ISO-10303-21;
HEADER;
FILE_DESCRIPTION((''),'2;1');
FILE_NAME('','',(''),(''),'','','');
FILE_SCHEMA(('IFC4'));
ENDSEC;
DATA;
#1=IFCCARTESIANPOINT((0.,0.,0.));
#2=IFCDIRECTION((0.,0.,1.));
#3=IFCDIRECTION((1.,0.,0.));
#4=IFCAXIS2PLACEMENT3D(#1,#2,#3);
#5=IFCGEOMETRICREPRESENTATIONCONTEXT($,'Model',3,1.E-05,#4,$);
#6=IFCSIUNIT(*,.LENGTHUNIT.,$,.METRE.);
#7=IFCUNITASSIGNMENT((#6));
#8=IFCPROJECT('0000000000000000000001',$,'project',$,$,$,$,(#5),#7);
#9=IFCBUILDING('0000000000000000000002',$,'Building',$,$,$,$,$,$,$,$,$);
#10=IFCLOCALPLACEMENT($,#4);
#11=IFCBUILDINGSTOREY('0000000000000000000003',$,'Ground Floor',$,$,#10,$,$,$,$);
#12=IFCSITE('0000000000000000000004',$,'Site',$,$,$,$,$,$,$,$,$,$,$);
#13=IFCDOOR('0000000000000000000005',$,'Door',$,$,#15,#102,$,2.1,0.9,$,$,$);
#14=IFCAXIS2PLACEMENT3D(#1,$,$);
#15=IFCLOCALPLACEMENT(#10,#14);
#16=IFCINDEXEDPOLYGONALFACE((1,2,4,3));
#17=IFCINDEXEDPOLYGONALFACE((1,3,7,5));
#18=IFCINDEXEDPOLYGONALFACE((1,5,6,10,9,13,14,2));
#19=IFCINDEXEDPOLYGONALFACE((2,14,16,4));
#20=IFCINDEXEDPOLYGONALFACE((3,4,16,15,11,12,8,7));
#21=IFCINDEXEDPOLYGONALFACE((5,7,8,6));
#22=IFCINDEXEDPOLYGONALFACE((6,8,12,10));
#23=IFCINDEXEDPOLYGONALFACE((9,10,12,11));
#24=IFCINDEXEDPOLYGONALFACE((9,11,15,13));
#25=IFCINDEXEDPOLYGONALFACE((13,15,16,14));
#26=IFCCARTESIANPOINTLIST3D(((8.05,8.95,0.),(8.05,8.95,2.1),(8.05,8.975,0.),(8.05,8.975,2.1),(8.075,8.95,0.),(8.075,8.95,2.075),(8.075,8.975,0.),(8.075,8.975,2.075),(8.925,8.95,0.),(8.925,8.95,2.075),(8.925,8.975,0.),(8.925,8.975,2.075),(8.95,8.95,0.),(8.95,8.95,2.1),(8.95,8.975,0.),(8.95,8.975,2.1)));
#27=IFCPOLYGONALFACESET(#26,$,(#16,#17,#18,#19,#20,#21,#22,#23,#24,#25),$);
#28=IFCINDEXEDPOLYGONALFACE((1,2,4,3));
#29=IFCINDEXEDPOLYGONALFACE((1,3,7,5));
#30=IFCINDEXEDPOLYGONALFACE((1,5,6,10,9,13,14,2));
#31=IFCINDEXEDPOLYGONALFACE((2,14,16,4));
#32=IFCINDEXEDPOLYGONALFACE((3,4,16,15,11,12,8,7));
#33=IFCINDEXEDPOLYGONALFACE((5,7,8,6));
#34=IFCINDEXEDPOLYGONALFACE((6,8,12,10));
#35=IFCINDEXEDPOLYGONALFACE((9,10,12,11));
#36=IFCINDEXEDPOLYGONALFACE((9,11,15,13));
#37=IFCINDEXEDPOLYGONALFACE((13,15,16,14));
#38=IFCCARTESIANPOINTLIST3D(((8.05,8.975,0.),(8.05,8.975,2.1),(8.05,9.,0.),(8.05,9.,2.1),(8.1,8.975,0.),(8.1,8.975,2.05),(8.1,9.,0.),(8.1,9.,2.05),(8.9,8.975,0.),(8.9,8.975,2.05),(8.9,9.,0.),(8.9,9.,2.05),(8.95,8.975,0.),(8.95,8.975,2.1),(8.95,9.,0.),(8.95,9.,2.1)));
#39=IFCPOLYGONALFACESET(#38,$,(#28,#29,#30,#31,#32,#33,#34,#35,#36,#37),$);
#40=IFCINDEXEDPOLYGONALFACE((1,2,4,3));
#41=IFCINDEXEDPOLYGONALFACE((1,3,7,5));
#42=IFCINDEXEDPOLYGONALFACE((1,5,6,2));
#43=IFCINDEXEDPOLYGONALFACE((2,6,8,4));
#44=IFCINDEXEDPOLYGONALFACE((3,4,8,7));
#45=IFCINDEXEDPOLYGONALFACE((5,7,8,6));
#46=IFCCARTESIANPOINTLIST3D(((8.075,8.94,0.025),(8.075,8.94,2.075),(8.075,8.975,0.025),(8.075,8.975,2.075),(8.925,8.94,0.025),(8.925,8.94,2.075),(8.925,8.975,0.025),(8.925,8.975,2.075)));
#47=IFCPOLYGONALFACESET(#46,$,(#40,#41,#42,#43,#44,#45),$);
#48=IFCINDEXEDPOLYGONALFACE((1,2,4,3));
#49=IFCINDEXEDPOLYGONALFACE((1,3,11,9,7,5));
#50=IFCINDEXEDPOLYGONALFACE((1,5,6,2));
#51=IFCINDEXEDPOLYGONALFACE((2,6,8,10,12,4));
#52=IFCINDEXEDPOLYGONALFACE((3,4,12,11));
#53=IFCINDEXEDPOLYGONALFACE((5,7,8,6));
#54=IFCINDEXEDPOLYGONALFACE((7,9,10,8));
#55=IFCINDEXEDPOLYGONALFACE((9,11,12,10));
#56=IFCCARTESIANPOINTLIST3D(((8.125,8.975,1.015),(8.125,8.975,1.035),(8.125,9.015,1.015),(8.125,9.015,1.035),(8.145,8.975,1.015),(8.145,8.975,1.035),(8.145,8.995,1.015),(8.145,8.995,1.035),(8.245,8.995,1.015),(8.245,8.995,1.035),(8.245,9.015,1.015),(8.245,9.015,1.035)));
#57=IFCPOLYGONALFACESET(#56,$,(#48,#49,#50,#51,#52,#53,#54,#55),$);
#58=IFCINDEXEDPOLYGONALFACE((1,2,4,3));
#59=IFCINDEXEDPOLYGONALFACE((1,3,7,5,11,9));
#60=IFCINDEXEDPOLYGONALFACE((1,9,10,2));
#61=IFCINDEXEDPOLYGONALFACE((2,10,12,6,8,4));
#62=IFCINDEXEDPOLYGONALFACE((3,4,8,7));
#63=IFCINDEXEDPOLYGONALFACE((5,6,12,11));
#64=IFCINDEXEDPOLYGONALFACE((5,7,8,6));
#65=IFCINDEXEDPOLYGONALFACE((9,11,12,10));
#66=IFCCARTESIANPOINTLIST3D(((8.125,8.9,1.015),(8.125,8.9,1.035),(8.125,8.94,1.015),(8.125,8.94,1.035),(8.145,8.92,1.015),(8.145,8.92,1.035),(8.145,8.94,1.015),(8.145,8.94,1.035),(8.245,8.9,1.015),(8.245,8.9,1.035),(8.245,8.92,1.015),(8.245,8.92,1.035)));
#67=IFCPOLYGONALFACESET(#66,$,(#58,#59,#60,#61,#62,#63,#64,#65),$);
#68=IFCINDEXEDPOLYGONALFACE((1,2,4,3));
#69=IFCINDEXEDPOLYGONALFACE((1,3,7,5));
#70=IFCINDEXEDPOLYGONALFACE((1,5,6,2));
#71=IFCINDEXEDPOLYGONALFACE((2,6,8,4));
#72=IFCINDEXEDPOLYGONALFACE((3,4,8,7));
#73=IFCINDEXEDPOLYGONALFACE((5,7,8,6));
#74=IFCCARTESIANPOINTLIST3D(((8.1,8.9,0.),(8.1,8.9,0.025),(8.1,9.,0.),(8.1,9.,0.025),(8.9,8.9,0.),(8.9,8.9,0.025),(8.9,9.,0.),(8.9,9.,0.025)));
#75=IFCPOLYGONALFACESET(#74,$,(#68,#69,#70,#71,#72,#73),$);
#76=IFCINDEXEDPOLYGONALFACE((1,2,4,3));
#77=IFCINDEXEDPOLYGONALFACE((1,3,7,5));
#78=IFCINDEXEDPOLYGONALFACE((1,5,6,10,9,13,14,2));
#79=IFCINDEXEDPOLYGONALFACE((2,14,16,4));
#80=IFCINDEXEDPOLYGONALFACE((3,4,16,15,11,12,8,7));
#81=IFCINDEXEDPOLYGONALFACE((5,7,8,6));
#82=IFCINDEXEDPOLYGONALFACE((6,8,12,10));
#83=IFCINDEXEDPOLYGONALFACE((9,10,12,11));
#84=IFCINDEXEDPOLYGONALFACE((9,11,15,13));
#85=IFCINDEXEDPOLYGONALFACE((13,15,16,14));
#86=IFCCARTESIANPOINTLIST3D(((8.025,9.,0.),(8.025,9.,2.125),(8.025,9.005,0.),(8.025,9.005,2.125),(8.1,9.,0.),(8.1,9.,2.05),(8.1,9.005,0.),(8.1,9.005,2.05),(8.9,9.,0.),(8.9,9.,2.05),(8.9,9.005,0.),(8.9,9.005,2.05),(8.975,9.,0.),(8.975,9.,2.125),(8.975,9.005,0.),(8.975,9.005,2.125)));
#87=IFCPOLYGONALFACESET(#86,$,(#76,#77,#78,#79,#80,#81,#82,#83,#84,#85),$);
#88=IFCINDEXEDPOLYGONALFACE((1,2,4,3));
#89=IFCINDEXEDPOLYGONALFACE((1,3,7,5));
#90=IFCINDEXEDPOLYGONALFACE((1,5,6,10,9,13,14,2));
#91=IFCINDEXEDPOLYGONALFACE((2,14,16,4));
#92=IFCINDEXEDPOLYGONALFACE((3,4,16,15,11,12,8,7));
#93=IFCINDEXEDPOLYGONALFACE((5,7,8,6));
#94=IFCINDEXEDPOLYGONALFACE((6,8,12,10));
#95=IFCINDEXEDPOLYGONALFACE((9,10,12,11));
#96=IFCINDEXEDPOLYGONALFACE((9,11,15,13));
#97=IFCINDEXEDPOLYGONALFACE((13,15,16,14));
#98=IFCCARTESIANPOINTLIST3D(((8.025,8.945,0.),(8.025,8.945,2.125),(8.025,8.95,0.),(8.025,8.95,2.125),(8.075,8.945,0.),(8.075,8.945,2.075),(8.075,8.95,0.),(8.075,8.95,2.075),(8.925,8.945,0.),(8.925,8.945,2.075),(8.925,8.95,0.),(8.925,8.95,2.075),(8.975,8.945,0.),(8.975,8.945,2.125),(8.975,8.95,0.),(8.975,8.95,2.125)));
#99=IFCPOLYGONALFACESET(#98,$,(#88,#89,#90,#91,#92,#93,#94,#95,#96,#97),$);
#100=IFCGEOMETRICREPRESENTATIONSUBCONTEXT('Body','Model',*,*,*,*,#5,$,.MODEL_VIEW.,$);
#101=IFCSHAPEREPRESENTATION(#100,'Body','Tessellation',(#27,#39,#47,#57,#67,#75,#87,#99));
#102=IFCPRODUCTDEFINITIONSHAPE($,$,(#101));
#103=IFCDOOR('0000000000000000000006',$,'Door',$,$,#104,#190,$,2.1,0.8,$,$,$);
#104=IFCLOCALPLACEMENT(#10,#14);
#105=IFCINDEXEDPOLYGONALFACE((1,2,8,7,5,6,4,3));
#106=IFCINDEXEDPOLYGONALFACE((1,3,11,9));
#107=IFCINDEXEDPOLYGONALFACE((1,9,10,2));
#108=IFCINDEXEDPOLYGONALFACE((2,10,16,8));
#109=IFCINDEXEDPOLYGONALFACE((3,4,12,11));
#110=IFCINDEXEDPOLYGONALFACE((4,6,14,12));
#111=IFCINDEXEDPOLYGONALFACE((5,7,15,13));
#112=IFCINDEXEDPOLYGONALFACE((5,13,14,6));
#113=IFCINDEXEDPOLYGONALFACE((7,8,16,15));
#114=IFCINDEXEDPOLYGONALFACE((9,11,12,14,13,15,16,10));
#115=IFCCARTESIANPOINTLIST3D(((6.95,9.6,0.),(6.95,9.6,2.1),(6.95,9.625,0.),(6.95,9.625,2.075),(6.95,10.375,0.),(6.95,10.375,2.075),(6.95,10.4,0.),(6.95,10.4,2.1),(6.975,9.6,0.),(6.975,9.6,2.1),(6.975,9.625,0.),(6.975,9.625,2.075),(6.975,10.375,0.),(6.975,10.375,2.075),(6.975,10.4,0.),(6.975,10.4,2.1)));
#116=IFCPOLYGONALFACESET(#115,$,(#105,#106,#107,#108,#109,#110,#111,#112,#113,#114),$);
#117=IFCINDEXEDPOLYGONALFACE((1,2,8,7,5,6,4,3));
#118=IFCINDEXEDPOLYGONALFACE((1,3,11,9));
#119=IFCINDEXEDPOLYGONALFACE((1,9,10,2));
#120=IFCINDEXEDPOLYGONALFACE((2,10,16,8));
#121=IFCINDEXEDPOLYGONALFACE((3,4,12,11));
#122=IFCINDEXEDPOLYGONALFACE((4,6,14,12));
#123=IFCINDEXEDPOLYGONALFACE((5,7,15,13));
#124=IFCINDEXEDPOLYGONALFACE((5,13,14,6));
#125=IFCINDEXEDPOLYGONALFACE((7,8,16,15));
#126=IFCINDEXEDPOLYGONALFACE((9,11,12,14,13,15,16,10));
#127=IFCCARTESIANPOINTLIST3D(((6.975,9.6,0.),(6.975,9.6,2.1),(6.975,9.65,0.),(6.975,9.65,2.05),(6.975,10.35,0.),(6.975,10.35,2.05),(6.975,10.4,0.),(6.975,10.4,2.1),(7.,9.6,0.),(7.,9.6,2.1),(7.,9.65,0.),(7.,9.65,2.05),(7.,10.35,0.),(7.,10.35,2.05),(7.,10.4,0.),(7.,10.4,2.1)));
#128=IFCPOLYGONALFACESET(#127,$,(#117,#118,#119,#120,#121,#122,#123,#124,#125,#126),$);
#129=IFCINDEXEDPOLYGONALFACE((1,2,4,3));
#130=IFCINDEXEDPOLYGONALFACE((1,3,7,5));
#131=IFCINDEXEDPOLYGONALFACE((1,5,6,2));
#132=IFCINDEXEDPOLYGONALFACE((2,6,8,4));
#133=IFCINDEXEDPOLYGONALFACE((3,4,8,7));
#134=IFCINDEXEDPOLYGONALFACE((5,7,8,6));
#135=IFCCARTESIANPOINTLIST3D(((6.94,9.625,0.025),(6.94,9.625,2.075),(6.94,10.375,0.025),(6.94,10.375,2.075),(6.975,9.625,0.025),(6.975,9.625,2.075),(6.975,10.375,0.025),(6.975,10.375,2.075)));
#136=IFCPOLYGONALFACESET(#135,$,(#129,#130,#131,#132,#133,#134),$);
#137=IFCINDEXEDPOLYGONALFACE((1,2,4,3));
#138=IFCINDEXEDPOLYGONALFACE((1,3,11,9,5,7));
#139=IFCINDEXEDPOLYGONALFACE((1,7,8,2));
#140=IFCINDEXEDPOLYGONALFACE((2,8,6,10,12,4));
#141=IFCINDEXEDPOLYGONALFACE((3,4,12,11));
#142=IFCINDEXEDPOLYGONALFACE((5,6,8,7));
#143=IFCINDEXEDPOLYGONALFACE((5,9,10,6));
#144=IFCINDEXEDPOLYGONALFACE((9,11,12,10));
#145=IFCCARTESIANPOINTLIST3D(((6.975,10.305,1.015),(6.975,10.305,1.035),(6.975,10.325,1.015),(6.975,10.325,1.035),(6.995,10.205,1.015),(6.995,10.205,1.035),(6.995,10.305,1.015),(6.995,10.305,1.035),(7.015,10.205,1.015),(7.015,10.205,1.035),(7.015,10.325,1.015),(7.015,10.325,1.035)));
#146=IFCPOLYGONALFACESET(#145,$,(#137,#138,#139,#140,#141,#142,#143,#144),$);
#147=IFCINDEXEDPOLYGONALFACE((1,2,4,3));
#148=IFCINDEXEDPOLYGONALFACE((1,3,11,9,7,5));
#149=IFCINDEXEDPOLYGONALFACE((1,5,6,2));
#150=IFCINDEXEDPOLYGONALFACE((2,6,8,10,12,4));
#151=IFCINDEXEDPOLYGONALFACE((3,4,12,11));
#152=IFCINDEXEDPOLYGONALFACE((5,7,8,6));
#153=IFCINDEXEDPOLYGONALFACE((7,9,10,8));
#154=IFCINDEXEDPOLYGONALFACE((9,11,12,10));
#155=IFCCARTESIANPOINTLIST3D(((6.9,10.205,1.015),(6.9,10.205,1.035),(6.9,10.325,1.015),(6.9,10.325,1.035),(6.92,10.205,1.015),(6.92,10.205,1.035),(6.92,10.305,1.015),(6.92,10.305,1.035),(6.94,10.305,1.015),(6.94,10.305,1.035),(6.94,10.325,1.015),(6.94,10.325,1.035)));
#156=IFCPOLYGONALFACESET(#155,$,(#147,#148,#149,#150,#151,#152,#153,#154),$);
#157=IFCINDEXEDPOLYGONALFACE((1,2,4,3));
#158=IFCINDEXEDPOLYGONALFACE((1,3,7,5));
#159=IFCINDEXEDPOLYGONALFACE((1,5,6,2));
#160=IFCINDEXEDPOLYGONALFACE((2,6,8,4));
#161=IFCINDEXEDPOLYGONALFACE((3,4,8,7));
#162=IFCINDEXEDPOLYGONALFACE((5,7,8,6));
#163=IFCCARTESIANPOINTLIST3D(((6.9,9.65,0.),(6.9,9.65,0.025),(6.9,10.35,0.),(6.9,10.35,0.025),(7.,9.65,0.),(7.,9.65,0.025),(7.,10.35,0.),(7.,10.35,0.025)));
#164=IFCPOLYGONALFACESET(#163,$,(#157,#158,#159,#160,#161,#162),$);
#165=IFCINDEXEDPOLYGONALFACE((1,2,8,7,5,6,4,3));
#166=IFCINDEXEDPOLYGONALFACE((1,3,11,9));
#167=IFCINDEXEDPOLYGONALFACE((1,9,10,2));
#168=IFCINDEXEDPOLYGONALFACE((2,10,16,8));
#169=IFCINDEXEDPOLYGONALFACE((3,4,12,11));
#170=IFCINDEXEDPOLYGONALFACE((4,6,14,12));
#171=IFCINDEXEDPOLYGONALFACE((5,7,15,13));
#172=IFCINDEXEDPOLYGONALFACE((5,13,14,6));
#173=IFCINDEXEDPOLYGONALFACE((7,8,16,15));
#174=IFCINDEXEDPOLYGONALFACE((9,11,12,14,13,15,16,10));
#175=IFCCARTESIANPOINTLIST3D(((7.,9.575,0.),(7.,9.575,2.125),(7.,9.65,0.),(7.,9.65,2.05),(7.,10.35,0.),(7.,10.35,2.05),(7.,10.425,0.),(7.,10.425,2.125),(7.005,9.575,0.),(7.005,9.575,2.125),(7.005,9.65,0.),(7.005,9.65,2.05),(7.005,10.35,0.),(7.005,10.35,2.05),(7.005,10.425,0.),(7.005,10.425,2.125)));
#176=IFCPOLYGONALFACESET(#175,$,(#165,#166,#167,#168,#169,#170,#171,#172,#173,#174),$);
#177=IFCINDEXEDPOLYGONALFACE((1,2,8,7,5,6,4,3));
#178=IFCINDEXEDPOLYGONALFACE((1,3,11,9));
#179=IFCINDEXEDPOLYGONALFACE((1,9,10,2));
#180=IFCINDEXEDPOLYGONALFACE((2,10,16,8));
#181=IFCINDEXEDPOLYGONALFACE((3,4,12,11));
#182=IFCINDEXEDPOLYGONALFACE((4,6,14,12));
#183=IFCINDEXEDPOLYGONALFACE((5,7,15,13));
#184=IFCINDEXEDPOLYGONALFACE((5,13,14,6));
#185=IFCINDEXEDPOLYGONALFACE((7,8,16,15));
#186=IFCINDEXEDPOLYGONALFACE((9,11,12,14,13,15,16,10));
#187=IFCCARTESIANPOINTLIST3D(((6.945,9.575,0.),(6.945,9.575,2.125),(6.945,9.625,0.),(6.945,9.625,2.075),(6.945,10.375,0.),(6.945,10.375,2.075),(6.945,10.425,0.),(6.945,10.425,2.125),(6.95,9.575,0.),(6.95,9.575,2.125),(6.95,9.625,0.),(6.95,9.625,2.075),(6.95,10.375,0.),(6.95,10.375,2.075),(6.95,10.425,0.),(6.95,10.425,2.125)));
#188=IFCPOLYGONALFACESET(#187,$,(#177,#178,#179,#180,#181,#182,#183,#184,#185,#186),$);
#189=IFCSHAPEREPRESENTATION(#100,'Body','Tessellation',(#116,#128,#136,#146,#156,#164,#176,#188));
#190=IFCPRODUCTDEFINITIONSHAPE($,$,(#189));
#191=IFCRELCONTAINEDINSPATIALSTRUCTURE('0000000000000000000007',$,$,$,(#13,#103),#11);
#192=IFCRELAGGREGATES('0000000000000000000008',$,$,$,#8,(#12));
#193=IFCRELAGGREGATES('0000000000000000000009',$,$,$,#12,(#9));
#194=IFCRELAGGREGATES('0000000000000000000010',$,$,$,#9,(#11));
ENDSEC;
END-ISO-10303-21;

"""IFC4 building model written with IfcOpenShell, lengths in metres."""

from ifc_helpers import new_model, si_unit, frame, origin_with_axes, place, context, subcontext, project, spatial, line, indexed_curve, outline, extrude, element, save


model = new_model("IFC4")

# Units and contexts
model_context = context("Model", 3, precision=1e-05, world=origin_with_axes())
body_context = subcontext(model_context, "Body", "Model", "MODEL_VIEW")
ifc_project = project(units=[si_unit("LENGTHUNIT", "METRE")], contexts=[model_context])

# Site, building, storey
site = spatial("IfcSite", under=ifc_project, Name="Site")
building = spatial("IfcBuilding", under=site, Name="Building")
storey_placement = place(None, origin_with_axes())
storey = spatial("IfcBuildingStorey", under=building, at=storey_placement, Name="Ground Floor")

# Doors
door_1_placement = place(storey_placement, frame((8.95, 9.0, 0.0), z_axis=(0.0, 0.0, 1.0), x_axis=(-1.0, 0.0, 0.0)))
element("IfcDoor", 1, at=door_1_placement, inside=storey, Name="Door", OverallHeight=2.1, OverallWidth=0.9, context=body_context, shape_type="SweptSolid", body=[
    extrude(outline(indexed_curve([(0.0, 0.0), (0.0, 2.1), (0.9, 2.1), (0.9, 0.0), (0.875, 0.0), (0.875, 2.075), (0.025, 2.075), (0.025, 0.0)], segments=[line(1, 2, 3, 4, 5, 6, 7, 8, 1)])), frame((0.0, 0.025, 0.0), z_axis=(0.0, -1.0, 0.0), x_axis=(1.0, 0.0, 0.0)), (0.0, 0.0, -1.0), 0.025),
    extrude(outline(indexed_curve([(0.0, 0.0), (0.0, 2.1), (0.9, 2.1), (0.9, 0.0), (0.85, 0.0), (0.85, 2.05), (0.05, 2.05), (0.05, 0.0)], segments=[line(1, 2, 3, 4, 5, 6, 7, 8, 1)])), frame((0.0, 0.0, 0.0), z_axis=(0.0, -1.0, 0.0), x_axis=(1.0, 0.0, 0.0)), (0.0, 0.0, -1.0), 0.025),
    extrude(outline(indexed_curve([(0.0, 0.0), (0.85, 0.0), (0.85, 0.035), (0.0, 0.035)], segments=[line(1, 2, 3, 4, 1)])), frame((0.025, 0.025, 0.025), z_axis=(0.0, 0.0, 1.0), x_axis=(1.0, 0.0, 0.0)), (0.0, 0.0, 1.0), 2.05),
    extrude(outline(indexed_curve([(0.0, 0.0), (0.0, -0.04), (-0.12, -0.04), (-0.12, -0.02), (-0.02, -0.02), (-0.02, 0.0)], segments=[line(1, 2, 3, 4, 5, 6, 1)])), frame((0.825, 0.025, 1.015), z_axis=(0.0, 0.0, 1.0), x_axis=(1.0, 0.0, 0.0)), (0.0, 0.0, 1.0), 0.02),
    extrude(outline(indexed_curve([(0.0, 0.0), (0.0, 0.04), (-0.12, 0.04), (-0.12, 0.02), (-0.02, 0.02), (-0.02, 0.0)], segments=[line(1, 2, 3, 4, 5, 6, 1)])), frame((0.825, 0.06, 1.015), z_axis=(0.0, 0.0, 1.0), x_axis=(1.0, 0.0, 0.0)), (0.0, 0.0, 1.0), 0.02),
    extrude(outline(indexed_curve([(0.0, 0.0), (0.8, 0.0), (0.8, 0.1), (0.0, 0.1)], segments=[line(1, 2, 3, 4, 1)])), frame((0.05, 0.0, 0.0), z_axis=(0.0, 0.0, 1.0), x_axis=(1.0, 0.0, 0.0)), (0.0, 0.0, 1.0), 0.025),
    extrude(outline(indexed_curve([(0.0, 0.0), (0.0, 2.125), (0.95, 2.125), (0.95, 0.0), (0.875, 0.0), (0.875, 2.05), (0.075, 2.05), (0.075, 0.0)], segments=[line(1, 2, 3, 4, 5, 6, 7, 8, 1)])), frame((-0.025, -0.005, 0.0), z_axis=(0.0, -1.0, 0.0), x_axis=(1.0, 0.0, 0.0)), (0.0, 0.0, -1.0), 0.005),
    extrude(outline(indexed_curve([(0.0, 0.0), (0.0, 2.125), (0.95, 2.125), (0.95, 0.0), (0.9, 0.0), (0.9, 2.075), (0.05, 2.075), (0.05, 0.0)], segments=[line(1, 2, 3, 4, 5, 6, 7, 8, 1)])), frame((-0.025, 0.05, 0.0), z_axis=(0.0, -1.0, 0.0), x_axis=(1.0, 0.0, 0.0)), (0.0, 0.0, -1.0), 0.005),
])
door_2_placement = place(storey_placement, frame((7.0, 9.6, 0.0), z_axis=(0.0, 0.0, 1.0), x_axis=(0.0, 1.0, 0.0)))
element("IfcDoor", 2, at=door_2_placement, inside=storey, Name="Door", OverallHeight=2.1, OverallWidth=0.8, context=body_context, shape_type="SweptSolid", body=[
    extrude(outline(indexed_curve([(0.0, 0.0), (0.0, 2.1), (0.8, 2.1), (0.8, 0.0), (0.775, 0.0), (0.775, 2.075), (0.025, 2.075), (0.025, 0.0)], segments=[line(1, 2, 3, 4, 5, 6, 7, 8, 1)])), frame((0.0, 0.025, 0.0), z_axis=(0.0, -1.0, 0.0), x_axis=(1.0, 0.0, 0.0)), (0.0, 0.0, -1.0), 0.025),
    extrude(outline(indexed_curve([(0.0, 0.0), (0.0, 2.1), (0.8, 2.1), (0.8, 0.0), (0.75, 0.0), (0.75, 2.05), (0.05, 2.05), (0.05, 0.0)], segments=[line(1, 2, 3, 4, 5, 6, 7, 8, 1)])), frame((0.0, 0.0, 0.0), z_axis=(0.0, -1.0, 0.0), x_axis=(1.0, 0.0, 0.0)), (0.0, 0.0, -1.0), 0.025),
    extrude(outline(indexed_curve([(0.0, 0.0), (0.75, 0.0), (0.75, 0.035), (0.0, 0.035)], segments=[line(1, 2, 3, 4, 1)])), frame((0.025, 0.025, 0.025), z_axis=(0.0, 0.0, 1.0), x_axis=(1.0, 0.0, 0.0)), (0.0, 0.0, 1.0), 2.05),
    extrude(outline(indexed_curve([(0.0, 0.0), (0.0, -0.04), (-0.12, -0.04), (-0.12, -0.02), (-0.02, -0.02), (-0.02, 0.0)], segments=[line(1, 2, 3, 4, 5, 6, 1)])), frame((0.725, 0.025, 1.015), z_axis=(0.0, 0.0, 1.0), x_axis=(1.0, 0.0, 0.0)), (0.0, 0.0, 1.0), 0.02),
    extrude(outline(indexed_curve([(0.0, 0.0), (0.0, 0.04), (-0.12, 0.04), (-0.12, 0.02), (-0.02, 0.02), (-0.02, 0.0)], segments=[line(1, 2, 3, 4, 5, 6, 1)])), frame((0.725, 0.06, 1.015), z_axis=(0.0, 0.0, 1.0), x_axis=(1.0, 0.0, 0.0)), (0.0, 0.0, 1.0), 0.02),
    extrude(outline(indexed_curve([(0.0, 0.0), (0.7, 0.0), (0.7, 0.1), (0.0, 0.1)], segments=[line(1, 2, 3, 4, 1)])), frame((0.05, 0.0, 0.0), z_axis=(0.0, 0.0, 1.0), x_axis=(1.0, 0.0, 0.0)), (0.0, 0.0, 1.0), 0.025),
    extrude(outline(indexed_curve([(0.0, 0.0), (0.0, 2.125), (0.85, 2.125), (0.85, 0.0), (0.775, 0.0), (0.775, 2.05), (0.075, 2.05), (0.075, 0.0)], segments=[line(1, 2, 3, 4, 5, 6, 7, 8, 1)])), frame((-0.025, -0.005, 0.0), z_axis=(0.0, -1.0, 0.0), x_axis=(1.0, 0.0, 0.0)), (0.0, 0.0, -1.0), 0.005),
    extrude(outline(indexed_curve([(0.0, 0.0), (0.0, 2.125), (0.85, 2.125), (0.85, 0.0), (0.8, 0.0), (0.8, 2.075), (0.05, 2.075), (0.05, 0.0)], segments=[line(1, 2, 3, 4, 5, 6, 7, 8, 1)])), frame((-0.025, 0.05, 0.0), z_axis=(0.0, -1.0, 0.0), x_axis=(1.0, 0.0, 0.0)), (0.0, 0.0, -1.0), 0.005),
])

save(model, "model.ifc")
